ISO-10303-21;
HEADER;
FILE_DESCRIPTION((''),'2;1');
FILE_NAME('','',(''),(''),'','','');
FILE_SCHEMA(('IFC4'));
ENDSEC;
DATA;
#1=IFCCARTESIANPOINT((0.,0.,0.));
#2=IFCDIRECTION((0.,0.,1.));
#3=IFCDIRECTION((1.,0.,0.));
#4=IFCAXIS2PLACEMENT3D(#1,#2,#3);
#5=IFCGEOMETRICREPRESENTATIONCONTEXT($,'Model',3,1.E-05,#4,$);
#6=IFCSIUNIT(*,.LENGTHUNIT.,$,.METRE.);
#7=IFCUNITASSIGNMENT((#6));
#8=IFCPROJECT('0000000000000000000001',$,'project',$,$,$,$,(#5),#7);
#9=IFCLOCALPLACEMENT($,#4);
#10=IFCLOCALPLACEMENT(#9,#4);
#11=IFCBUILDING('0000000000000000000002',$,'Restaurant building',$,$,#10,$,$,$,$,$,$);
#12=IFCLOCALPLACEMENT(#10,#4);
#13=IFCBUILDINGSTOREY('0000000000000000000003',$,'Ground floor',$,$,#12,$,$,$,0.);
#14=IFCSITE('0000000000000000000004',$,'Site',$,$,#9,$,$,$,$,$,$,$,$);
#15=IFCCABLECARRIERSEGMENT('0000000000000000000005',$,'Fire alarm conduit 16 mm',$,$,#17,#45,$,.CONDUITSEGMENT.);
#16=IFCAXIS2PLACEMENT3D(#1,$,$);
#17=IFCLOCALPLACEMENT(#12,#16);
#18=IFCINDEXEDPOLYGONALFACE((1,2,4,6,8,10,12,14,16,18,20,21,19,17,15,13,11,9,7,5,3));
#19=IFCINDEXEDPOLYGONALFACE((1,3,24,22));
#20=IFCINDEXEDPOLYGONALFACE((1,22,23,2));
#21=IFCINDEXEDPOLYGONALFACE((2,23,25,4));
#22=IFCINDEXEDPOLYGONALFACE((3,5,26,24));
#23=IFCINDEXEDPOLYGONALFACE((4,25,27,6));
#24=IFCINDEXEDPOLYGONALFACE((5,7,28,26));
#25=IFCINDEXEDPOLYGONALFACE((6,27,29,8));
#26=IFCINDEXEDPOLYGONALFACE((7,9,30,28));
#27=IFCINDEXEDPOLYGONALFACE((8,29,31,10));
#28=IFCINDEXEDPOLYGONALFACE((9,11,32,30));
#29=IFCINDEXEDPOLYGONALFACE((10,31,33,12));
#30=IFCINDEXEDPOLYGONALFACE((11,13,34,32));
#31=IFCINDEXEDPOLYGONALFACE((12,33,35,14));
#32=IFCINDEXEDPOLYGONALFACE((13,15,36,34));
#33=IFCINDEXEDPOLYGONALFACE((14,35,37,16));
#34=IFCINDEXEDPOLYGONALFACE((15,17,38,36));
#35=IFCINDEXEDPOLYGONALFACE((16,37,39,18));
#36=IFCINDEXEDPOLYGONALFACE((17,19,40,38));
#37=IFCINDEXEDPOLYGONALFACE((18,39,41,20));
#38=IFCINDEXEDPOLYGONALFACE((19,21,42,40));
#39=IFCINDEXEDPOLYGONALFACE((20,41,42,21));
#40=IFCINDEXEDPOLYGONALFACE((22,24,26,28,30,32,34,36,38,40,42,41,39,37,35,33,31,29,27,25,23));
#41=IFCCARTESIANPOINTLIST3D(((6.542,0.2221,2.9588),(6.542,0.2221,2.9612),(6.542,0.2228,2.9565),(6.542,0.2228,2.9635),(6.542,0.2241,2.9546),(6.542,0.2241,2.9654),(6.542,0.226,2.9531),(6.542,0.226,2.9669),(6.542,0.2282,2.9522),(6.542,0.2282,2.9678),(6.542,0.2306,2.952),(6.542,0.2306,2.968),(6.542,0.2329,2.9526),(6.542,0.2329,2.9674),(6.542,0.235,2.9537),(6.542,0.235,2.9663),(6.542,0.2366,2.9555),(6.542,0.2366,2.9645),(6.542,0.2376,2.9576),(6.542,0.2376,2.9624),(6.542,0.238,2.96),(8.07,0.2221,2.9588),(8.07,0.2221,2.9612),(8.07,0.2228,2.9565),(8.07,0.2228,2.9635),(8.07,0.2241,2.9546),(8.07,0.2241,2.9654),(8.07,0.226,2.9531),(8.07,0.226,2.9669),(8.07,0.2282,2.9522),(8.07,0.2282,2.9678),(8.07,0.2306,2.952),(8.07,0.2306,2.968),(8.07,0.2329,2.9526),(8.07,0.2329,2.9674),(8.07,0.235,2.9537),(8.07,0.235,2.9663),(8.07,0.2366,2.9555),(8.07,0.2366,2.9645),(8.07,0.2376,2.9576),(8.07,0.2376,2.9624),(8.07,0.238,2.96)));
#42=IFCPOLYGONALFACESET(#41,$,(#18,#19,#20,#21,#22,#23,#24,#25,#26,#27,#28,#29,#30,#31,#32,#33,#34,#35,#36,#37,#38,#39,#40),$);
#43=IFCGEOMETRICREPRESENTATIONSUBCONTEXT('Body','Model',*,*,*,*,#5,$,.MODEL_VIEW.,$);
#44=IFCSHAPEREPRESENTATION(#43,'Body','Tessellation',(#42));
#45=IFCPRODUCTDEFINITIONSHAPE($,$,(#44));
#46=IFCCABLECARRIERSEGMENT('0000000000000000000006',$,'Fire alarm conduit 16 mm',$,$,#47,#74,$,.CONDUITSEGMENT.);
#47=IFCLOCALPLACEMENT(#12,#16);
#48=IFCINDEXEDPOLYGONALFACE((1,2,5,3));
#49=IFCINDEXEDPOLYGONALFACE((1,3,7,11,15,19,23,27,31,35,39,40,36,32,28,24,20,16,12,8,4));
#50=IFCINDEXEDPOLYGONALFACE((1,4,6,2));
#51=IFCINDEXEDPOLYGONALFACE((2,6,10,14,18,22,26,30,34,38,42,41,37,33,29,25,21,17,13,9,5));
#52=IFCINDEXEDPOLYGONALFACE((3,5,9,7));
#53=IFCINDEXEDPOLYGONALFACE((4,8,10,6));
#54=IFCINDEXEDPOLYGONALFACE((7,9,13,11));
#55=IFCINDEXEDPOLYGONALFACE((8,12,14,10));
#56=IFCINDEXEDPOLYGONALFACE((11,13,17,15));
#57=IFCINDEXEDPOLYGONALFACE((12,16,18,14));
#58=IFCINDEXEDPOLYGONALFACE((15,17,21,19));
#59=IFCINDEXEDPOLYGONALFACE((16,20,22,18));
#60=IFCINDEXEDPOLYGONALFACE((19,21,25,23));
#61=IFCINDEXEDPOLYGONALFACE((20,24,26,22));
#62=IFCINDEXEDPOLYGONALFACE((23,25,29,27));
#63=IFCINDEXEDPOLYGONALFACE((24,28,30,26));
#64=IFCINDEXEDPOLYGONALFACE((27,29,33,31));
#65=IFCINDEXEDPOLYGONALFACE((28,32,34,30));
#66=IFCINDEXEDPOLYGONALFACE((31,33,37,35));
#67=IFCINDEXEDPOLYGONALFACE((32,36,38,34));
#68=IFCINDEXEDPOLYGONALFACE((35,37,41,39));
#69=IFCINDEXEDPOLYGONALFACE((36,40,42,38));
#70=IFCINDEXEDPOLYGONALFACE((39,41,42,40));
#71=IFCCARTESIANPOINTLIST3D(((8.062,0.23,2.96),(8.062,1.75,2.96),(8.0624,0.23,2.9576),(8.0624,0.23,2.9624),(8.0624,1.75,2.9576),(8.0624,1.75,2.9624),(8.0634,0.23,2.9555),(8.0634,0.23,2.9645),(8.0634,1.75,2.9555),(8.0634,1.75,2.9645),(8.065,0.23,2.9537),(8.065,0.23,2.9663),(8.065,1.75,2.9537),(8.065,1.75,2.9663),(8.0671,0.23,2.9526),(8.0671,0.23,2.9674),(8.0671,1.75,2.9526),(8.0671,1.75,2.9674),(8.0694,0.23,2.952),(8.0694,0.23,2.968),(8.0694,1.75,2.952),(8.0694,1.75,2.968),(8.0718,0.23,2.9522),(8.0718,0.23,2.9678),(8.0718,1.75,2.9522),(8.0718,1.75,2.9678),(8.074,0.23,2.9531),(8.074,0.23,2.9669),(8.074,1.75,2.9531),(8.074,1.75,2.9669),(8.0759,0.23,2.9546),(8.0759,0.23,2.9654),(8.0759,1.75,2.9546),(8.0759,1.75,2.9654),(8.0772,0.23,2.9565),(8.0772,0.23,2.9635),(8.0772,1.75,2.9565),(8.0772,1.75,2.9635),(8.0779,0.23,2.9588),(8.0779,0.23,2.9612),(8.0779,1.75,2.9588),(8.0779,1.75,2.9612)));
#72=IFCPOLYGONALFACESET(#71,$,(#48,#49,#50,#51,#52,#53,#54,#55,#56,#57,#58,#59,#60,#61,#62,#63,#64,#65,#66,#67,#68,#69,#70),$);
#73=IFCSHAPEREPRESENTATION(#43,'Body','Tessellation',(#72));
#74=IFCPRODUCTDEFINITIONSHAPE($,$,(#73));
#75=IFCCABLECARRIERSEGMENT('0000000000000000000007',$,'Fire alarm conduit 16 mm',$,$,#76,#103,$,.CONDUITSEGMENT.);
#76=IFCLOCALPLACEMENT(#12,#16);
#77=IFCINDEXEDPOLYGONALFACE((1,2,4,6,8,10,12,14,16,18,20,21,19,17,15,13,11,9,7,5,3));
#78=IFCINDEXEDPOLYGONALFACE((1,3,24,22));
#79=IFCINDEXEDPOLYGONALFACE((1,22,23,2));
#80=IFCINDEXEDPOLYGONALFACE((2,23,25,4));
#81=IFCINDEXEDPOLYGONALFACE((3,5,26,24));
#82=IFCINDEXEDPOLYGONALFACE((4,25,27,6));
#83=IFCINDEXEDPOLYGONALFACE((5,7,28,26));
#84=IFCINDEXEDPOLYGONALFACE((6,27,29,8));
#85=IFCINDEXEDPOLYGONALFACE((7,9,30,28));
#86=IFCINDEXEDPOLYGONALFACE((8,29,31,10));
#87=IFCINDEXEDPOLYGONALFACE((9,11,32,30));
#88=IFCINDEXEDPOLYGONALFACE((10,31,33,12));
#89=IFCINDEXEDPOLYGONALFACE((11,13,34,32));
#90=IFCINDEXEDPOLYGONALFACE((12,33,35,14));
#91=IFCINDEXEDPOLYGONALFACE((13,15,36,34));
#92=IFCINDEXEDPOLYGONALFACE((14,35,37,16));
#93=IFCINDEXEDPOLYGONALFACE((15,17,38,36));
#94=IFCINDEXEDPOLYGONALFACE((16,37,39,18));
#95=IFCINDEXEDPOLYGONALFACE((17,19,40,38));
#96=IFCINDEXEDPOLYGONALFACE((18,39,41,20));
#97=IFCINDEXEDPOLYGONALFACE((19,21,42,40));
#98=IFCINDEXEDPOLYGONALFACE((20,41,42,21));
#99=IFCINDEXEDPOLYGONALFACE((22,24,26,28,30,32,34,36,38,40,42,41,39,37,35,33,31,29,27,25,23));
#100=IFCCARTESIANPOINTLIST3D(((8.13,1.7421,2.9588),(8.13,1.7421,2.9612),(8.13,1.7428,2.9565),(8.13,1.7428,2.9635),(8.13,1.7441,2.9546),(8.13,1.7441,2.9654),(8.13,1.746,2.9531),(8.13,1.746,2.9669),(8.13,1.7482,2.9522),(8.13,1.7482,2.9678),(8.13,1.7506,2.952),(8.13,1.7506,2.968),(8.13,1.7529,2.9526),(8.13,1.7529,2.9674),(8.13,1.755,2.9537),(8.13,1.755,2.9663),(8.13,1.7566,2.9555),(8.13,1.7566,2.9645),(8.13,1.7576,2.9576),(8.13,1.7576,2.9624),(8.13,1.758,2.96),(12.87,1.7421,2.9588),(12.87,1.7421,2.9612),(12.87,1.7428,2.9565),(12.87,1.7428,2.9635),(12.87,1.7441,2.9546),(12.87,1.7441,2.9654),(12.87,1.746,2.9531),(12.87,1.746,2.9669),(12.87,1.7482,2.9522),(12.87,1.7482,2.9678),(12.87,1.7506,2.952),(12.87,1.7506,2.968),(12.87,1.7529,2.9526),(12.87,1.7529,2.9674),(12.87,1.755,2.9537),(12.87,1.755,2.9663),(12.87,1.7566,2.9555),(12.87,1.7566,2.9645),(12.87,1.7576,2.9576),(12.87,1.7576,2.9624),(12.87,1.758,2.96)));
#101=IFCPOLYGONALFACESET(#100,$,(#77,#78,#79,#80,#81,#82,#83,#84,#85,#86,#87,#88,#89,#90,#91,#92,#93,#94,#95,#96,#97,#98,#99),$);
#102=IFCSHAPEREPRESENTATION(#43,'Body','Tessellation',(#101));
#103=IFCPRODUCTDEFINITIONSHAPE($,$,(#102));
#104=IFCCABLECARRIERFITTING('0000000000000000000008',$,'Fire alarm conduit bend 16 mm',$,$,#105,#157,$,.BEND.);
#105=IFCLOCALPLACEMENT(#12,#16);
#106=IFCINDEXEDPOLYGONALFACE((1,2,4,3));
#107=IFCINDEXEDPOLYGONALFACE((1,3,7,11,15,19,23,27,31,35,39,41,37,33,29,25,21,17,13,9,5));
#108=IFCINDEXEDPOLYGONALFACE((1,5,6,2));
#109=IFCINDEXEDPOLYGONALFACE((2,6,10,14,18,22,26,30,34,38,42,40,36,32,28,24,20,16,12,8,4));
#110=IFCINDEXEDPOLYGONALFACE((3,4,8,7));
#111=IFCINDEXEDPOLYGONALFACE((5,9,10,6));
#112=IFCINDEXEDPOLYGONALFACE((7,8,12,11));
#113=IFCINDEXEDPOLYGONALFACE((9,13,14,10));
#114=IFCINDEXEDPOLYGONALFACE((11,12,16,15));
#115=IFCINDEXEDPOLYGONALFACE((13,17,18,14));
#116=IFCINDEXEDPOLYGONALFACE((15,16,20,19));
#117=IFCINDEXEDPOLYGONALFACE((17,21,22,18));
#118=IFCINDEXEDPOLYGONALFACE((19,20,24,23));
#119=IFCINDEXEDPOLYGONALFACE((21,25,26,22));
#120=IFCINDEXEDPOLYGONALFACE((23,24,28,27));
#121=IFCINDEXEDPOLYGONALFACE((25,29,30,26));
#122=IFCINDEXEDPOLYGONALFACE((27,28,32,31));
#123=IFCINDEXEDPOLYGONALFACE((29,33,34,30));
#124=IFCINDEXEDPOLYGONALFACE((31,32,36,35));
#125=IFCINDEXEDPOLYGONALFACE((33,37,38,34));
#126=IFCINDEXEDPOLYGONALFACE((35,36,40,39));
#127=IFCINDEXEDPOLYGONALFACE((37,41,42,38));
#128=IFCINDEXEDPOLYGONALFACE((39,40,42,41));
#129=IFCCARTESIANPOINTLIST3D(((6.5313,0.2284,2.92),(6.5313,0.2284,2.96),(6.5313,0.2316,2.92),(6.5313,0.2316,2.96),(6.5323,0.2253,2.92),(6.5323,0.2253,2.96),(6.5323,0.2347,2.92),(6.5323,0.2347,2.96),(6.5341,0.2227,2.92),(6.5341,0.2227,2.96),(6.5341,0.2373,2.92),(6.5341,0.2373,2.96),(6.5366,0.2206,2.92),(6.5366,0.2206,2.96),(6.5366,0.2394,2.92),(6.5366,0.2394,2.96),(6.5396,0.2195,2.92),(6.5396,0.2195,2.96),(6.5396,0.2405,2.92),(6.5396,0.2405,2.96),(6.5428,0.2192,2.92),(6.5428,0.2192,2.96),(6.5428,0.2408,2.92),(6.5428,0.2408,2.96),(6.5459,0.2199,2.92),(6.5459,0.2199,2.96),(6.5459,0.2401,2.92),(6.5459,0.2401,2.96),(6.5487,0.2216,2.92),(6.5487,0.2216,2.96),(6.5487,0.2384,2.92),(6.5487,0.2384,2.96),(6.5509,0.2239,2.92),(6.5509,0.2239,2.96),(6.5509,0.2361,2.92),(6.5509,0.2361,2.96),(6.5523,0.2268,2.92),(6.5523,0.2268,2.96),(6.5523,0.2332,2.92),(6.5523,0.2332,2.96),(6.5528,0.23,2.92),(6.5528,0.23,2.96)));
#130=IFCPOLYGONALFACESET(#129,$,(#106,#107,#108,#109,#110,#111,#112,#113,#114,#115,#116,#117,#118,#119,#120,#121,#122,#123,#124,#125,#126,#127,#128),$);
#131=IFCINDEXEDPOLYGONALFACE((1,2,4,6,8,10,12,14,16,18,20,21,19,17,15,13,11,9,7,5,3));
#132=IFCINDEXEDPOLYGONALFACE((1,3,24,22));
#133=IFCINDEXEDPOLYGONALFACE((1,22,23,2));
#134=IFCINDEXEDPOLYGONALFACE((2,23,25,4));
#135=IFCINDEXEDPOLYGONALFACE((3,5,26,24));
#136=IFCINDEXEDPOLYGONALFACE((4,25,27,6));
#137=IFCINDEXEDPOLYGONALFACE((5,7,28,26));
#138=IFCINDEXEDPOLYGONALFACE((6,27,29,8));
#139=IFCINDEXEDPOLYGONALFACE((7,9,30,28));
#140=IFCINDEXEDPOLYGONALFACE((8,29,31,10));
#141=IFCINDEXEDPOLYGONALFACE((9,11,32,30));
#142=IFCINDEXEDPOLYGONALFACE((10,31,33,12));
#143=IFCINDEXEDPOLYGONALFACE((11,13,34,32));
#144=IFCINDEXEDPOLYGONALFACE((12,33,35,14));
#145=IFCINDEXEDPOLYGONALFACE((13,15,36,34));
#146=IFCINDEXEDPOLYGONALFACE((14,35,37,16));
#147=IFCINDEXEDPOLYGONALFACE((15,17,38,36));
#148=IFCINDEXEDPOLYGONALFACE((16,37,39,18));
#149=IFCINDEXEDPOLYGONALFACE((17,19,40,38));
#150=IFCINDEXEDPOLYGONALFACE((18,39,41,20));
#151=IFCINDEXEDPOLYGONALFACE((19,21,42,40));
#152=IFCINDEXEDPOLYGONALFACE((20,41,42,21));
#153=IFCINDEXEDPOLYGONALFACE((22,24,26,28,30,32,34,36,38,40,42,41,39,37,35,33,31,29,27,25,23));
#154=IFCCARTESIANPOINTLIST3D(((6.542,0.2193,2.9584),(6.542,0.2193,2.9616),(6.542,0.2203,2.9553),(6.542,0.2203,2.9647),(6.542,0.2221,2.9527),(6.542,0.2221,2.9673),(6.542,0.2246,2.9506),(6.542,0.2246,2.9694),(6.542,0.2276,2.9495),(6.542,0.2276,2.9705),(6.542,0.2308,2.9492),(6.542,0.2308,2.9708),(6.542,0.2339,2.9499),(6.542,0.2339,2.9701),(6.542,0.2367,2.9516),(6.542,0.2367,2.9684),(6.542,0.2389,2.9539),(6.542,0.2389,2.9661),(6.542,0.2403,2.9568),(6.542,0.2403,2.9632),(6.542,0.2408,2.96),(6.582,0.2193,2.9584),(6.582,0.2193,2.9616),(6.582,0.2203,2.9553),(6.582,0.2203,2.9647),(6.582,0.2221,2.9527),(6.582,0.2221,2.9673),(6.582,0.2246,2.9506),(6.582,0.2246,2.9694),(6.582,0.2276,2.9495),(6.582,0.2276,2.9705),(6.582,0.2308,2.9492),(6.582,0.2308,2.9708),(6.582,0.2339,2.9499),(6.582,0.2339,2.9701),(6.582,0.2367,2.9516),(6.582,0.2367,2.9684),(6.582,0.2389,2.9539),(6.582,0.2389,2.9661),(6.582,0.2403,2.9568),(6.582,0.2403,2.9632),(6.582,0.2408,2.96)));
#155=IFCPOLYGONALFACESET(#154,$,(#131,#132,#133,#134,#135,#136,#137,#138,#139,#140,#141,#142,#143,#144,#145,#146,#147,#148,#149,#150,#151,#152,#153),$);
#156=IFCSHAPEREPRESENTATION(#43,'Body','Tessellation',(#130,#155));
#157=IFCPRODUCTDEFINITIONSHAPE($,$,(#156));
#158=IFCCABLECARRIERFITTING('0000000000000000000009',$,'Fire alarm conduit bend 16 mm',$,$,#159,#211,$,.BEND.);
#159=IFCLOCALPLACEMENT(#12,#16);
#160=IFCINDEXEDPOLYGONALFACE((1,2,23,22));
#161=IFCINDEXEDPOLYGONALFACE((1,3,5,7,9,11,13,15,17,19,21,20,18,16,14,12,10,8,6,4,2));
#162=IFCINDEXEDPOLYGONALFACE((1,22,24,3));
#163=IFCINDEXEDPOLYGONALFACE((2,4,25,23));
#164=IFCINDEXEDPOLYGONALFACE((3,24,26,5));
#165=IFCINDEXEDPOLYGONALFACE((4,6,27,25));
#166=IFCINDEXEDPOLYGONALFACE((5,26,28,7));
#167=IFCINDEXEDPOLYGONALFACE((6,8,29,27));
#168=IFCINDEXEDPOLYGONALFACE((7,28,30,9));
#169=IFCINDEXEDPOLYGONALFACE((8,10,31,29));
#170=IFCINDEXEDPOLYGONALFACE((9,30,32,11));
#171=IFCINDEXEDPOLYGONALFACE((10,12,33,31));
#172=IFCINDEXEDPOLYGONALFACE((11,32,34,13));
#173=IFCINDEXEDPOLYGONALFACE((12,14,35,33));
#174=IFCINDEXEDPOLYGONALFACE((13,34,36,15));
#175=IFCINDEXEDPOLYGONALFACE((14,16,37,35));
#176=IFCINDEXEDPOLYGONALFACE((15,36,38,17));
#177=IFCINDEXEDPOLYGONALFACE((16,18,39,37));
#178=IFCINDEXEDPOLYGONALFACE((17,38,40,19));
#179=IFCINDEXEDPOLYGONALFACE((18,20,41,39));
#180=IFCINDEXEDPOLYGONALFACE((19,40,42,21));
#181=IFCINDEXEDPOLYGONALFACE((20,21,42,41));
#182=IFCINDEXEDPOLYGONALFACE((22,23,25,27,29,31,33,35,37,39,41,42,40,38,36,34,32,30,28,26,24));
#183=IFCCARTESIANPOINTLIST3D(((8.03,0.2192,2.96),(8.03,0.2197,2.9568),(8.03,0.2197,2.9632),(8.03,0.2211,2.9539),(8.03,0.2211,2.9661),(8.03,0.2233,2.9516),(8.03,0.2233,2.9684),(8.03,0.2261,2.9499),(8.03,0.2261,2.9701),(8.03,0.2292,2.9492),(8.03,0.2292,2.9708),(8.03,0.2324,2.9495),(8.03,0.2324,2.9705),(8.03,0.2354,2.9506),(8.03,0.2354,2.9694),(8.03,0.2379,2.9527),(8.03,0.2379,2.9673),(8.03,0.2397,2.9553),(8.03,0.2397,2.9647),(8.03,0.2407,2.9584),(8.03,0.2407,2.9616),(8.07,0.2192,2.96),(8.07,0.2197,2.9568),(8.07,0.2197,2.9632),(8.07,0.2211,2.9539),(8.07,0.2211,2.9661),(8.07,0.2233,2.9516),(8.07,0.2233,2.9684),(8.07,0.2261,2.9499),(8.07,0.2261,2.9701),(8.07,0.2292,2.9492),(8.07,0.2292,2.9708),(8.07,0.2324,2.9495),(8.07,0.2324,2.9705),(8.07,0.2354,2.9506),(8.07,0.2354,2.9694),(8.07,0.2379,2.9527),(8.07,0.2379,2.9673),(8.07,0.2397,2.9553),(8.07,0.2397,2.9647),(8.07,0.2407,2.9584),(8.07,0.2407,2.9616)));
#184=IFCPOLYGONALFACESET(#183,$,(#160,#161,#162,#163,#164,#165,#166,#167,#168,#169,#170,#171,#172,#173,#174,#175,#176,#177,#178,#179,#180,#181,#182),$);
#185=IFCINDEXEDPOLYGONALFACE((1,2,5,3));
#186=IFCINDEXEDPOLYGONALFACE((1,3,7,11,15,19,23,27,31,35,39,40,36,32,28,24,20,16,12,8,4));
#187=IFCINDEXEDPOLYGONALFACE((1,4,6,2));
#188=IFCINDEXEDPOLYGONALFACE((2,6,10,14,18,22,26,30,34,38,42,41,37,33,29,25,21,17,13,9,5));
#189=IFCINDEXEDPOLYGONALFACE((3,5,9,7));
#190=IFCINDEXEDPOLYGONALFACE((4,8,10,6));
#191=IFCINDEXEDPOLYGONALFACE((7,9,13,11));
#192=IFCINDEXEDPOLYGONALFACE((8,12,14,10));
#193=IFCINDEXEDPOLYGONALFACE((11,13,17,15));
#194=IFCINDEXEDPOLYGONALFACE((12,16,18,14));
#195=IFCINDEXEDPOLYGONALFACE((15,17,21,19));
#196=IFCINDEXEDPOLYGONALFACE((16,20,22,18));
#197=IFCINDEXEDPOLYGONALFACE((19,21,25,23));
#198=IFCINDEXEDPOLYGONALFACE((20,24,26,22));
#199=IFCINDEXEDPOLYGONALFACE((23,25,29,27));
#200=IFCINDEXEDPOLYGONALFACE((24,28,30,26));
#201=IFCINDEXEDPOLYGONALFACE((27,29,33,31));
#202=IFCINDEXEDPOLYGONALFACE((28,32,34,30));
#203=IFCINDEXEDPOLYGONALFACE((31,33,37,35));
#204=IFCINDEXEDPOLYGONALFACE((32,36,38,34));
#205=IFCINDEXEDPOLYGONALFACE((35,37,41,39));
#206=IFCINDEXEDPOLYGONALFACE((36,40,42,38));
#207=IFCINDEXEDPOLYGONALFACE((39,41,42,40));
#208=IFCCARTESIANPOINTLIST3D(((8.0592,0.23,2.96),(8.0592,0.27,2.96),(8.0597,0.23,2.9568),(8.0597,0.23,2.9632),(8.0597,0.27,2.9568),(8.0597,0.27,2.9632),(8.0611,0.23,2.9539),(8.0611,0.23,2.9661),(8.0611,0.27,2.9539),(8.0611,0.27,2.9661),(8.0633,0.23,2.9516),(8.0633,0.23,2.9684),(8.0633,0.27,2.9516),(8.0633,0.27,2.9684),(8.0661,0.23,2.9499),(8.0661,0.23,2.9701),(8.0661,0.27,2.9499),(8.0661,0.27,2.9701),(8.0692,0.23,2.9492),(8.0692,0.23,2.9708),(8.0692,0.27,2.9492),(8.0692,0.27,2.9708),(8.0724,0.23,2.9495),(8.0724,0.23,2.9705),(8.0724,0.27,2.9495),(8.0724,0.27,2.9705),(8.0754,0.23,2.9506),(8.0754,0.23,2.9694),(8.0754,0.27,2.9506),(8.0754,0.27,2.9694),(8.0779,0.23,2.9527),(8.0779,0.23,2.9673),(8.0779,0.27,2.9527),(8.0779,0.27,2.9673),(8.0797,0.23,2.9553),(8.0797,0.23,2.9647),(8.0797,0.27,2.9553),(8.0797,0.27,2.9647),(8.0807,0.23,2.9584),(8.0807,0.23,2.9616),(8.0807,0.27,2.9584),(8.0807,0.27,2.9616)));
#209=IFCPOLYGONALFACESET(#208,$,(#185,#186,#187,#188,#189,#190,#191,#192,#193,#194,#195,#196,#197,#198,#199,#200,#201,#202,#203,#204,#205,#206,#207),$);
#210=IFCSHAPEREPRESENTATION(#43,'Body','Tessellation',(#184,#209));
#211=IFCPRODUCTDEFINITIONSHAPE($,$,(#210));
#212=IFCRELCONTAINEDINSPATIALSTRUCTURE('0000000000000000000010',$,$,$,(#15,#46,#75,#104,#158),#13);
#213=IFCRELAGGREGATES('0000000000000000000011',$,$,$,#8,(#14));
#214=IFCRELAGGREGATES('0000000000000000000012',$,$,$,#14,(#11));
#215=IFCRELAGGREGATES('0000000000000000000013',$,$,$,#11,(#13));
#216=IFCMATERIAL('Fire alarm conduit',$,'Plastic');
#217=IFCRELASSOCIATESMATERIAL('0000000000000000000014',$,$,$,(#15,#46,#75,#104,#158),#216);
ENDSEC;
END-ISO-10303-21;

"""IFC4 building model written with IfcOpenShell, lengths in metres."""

from ifc_helpers import new_model, si_unit, frame, origin_with_axes, origin_2d, place, context, subcontext, project, spatial, circle, extrude, material, element, save


model = new_model("IFC4")

# Units and contexts
model_context = context("Model", 3, precision=1e-05, world=origin_with_axes())
body_context = subcontext(model_context, "Body", "Model", "MODEL_VIEW")
ifc_project = project(units=[si_unit("LENGTHUNIT", "METRE")], contexts=[model_context])

# Site, building, storey
site_placement = place(None, origin_with_axes())
site = spatial("IfcSite", under=ifc_project, at=site_placement, Name="Site")
building_placement = place(site_placement, origin_with_axes())
building = spatial("IfcBuilding", under=site, at=building_placement, Name="Restaurant building")
storey_placement = place(building_placement, origin_with_axes())
storey = spatial("IfcBuildingStorey", under=building, at=storey_placement, Name="Ground floor", Elevation=0.0)

# Cable carrier segments
ifc_material_1 = material(Name="Fire alarm conduit", Category="Plastic")
cable_carrier_segment_1_placement = place(storey_placement, frame((6.542, 0.23, 2.96)))
element("IfcCableCarrierSegment", 1, at=cable_carrier_segment_1_placement, inside=storey, material=ifc_material_1, Name="Fire alarm conduit 16 mm", PredefinedType="CONDUITSEGMENT", context=body_context, shape_type="SweptSolid", body=[
    extrude(circle(Radius=0.008, at=origin_2d()), frame((0.0, 0.0, 0.0), z_axis=(1.0, 0.0, 0.0), x_axis=(0.0, 1.0, 0.0)), (0.0, 0.0, 1.0), 1.528),
])
cable_carrier_segment_2_placement = place(storey_placement, frame((8.07, 0.23, 2.96)))
element("IfcCableCarrierSegment", 2, at=cable_carrier_segment_2_placement, inside=storey, material=ifc_material_1, Name="Fire alarm conduit 16 mm", PredefinedType="CONDUITSEGMENT", context=body_context, shape_type="SweptSolid", body=[
    extrude(circle(Radius=0.008, at=origin_2d()), frame((0.0, 0.0, 0.0), z_axis=(0.0, 1.0, 0.0), x_axis=(-1.0, 0.0, 0.0)), (0.0, 0.0, 1.0), 1.52),
])
cable_carrier_segment_3_placement = place(storey_placement, frame((8.13, 1.75, 2.96)))
element("IfcCableCarrierSegment", 3, at=cable_carrier_segment_3_placement, inside=storey, material=ifc_material_1, Name="Fire alarm conduit 16 mm", PredefinedType="CONDUITSEGMENT", context=body_context, shape_type="SweptSolid", body=[
    extrude(circle(Radius=0.008, at=origin_2d()), frame((0.0, 0.0, 0.0), z_axis=(1.0, 0.0, 0.0), x_axis=(0.0, 1.0, 0.0)), (0.0, 0.0, 1.0), 4.74),
])

# Cable carrier fittings
cable_carrier_fitting_1_placement = place(storey_placement, frame((6.542, 0.23, 2.96)))
element("IfcCableCarrierFitting", 4, at=cable_carrier_fitting_1_placement, inside=storey, material=ifc_material_1, Name="Fire alarm conduit bend 16 mm", PredefinedType="BEND", context=body_context, shape_type="SweptSolid", body=[
    extrude(circle(Radius=0.0108, at=origin_2d()), frame((0.0, 0.0, 0.0), z_axis=(0.0, 0.0, -1.0), x_axis=(1.0, 0.0, 0.0)), (0.0, 0.0, 1.0), 0.04),
    extrude(circle(Radius=0.0108, at=origin_2d()), frame((0.0, 0.0, 0.0), z_axis=(1.0, 0.0, 0.0), x_axis=(0.0, 1.0, 0.0)), (0.0, 0.0, 1.0), 0.04),
])
cable_carrier_fitting_2_placement = place(storey_placement, frame((8.07, 0.23, 2.96)))
element("IfcCableCarrierFitting", 5, at=cable_carrier_fitting_2_placement, inside=storey, material=ifc_material_1, Name="Fire alarm conduit bend 16 mm", PredefinedType="BEND", context=body_context, shape_type="SweptSolid", body=[
    extrude(circle(Radius=0.0108, at=origin_2d()), frame((0.0, 0.0, 0.0), z_axis=(-1.0, 0.0, 0.0), x_axis=(0.0, -1.0, 0.0)), (0.0, 0.0, 1.0), 0.04),
    extrude(circle(Radius=0.0108, at=origin_2d()), frame((0.0, 0.0, 0.0), z_axis=(0.0, 1.0, 0.0), x_axis=(-1.0, 0.0, 0.0)), (0.0, 0.0, 1.0), 0.04),
])

save(model, "model.ifc")
